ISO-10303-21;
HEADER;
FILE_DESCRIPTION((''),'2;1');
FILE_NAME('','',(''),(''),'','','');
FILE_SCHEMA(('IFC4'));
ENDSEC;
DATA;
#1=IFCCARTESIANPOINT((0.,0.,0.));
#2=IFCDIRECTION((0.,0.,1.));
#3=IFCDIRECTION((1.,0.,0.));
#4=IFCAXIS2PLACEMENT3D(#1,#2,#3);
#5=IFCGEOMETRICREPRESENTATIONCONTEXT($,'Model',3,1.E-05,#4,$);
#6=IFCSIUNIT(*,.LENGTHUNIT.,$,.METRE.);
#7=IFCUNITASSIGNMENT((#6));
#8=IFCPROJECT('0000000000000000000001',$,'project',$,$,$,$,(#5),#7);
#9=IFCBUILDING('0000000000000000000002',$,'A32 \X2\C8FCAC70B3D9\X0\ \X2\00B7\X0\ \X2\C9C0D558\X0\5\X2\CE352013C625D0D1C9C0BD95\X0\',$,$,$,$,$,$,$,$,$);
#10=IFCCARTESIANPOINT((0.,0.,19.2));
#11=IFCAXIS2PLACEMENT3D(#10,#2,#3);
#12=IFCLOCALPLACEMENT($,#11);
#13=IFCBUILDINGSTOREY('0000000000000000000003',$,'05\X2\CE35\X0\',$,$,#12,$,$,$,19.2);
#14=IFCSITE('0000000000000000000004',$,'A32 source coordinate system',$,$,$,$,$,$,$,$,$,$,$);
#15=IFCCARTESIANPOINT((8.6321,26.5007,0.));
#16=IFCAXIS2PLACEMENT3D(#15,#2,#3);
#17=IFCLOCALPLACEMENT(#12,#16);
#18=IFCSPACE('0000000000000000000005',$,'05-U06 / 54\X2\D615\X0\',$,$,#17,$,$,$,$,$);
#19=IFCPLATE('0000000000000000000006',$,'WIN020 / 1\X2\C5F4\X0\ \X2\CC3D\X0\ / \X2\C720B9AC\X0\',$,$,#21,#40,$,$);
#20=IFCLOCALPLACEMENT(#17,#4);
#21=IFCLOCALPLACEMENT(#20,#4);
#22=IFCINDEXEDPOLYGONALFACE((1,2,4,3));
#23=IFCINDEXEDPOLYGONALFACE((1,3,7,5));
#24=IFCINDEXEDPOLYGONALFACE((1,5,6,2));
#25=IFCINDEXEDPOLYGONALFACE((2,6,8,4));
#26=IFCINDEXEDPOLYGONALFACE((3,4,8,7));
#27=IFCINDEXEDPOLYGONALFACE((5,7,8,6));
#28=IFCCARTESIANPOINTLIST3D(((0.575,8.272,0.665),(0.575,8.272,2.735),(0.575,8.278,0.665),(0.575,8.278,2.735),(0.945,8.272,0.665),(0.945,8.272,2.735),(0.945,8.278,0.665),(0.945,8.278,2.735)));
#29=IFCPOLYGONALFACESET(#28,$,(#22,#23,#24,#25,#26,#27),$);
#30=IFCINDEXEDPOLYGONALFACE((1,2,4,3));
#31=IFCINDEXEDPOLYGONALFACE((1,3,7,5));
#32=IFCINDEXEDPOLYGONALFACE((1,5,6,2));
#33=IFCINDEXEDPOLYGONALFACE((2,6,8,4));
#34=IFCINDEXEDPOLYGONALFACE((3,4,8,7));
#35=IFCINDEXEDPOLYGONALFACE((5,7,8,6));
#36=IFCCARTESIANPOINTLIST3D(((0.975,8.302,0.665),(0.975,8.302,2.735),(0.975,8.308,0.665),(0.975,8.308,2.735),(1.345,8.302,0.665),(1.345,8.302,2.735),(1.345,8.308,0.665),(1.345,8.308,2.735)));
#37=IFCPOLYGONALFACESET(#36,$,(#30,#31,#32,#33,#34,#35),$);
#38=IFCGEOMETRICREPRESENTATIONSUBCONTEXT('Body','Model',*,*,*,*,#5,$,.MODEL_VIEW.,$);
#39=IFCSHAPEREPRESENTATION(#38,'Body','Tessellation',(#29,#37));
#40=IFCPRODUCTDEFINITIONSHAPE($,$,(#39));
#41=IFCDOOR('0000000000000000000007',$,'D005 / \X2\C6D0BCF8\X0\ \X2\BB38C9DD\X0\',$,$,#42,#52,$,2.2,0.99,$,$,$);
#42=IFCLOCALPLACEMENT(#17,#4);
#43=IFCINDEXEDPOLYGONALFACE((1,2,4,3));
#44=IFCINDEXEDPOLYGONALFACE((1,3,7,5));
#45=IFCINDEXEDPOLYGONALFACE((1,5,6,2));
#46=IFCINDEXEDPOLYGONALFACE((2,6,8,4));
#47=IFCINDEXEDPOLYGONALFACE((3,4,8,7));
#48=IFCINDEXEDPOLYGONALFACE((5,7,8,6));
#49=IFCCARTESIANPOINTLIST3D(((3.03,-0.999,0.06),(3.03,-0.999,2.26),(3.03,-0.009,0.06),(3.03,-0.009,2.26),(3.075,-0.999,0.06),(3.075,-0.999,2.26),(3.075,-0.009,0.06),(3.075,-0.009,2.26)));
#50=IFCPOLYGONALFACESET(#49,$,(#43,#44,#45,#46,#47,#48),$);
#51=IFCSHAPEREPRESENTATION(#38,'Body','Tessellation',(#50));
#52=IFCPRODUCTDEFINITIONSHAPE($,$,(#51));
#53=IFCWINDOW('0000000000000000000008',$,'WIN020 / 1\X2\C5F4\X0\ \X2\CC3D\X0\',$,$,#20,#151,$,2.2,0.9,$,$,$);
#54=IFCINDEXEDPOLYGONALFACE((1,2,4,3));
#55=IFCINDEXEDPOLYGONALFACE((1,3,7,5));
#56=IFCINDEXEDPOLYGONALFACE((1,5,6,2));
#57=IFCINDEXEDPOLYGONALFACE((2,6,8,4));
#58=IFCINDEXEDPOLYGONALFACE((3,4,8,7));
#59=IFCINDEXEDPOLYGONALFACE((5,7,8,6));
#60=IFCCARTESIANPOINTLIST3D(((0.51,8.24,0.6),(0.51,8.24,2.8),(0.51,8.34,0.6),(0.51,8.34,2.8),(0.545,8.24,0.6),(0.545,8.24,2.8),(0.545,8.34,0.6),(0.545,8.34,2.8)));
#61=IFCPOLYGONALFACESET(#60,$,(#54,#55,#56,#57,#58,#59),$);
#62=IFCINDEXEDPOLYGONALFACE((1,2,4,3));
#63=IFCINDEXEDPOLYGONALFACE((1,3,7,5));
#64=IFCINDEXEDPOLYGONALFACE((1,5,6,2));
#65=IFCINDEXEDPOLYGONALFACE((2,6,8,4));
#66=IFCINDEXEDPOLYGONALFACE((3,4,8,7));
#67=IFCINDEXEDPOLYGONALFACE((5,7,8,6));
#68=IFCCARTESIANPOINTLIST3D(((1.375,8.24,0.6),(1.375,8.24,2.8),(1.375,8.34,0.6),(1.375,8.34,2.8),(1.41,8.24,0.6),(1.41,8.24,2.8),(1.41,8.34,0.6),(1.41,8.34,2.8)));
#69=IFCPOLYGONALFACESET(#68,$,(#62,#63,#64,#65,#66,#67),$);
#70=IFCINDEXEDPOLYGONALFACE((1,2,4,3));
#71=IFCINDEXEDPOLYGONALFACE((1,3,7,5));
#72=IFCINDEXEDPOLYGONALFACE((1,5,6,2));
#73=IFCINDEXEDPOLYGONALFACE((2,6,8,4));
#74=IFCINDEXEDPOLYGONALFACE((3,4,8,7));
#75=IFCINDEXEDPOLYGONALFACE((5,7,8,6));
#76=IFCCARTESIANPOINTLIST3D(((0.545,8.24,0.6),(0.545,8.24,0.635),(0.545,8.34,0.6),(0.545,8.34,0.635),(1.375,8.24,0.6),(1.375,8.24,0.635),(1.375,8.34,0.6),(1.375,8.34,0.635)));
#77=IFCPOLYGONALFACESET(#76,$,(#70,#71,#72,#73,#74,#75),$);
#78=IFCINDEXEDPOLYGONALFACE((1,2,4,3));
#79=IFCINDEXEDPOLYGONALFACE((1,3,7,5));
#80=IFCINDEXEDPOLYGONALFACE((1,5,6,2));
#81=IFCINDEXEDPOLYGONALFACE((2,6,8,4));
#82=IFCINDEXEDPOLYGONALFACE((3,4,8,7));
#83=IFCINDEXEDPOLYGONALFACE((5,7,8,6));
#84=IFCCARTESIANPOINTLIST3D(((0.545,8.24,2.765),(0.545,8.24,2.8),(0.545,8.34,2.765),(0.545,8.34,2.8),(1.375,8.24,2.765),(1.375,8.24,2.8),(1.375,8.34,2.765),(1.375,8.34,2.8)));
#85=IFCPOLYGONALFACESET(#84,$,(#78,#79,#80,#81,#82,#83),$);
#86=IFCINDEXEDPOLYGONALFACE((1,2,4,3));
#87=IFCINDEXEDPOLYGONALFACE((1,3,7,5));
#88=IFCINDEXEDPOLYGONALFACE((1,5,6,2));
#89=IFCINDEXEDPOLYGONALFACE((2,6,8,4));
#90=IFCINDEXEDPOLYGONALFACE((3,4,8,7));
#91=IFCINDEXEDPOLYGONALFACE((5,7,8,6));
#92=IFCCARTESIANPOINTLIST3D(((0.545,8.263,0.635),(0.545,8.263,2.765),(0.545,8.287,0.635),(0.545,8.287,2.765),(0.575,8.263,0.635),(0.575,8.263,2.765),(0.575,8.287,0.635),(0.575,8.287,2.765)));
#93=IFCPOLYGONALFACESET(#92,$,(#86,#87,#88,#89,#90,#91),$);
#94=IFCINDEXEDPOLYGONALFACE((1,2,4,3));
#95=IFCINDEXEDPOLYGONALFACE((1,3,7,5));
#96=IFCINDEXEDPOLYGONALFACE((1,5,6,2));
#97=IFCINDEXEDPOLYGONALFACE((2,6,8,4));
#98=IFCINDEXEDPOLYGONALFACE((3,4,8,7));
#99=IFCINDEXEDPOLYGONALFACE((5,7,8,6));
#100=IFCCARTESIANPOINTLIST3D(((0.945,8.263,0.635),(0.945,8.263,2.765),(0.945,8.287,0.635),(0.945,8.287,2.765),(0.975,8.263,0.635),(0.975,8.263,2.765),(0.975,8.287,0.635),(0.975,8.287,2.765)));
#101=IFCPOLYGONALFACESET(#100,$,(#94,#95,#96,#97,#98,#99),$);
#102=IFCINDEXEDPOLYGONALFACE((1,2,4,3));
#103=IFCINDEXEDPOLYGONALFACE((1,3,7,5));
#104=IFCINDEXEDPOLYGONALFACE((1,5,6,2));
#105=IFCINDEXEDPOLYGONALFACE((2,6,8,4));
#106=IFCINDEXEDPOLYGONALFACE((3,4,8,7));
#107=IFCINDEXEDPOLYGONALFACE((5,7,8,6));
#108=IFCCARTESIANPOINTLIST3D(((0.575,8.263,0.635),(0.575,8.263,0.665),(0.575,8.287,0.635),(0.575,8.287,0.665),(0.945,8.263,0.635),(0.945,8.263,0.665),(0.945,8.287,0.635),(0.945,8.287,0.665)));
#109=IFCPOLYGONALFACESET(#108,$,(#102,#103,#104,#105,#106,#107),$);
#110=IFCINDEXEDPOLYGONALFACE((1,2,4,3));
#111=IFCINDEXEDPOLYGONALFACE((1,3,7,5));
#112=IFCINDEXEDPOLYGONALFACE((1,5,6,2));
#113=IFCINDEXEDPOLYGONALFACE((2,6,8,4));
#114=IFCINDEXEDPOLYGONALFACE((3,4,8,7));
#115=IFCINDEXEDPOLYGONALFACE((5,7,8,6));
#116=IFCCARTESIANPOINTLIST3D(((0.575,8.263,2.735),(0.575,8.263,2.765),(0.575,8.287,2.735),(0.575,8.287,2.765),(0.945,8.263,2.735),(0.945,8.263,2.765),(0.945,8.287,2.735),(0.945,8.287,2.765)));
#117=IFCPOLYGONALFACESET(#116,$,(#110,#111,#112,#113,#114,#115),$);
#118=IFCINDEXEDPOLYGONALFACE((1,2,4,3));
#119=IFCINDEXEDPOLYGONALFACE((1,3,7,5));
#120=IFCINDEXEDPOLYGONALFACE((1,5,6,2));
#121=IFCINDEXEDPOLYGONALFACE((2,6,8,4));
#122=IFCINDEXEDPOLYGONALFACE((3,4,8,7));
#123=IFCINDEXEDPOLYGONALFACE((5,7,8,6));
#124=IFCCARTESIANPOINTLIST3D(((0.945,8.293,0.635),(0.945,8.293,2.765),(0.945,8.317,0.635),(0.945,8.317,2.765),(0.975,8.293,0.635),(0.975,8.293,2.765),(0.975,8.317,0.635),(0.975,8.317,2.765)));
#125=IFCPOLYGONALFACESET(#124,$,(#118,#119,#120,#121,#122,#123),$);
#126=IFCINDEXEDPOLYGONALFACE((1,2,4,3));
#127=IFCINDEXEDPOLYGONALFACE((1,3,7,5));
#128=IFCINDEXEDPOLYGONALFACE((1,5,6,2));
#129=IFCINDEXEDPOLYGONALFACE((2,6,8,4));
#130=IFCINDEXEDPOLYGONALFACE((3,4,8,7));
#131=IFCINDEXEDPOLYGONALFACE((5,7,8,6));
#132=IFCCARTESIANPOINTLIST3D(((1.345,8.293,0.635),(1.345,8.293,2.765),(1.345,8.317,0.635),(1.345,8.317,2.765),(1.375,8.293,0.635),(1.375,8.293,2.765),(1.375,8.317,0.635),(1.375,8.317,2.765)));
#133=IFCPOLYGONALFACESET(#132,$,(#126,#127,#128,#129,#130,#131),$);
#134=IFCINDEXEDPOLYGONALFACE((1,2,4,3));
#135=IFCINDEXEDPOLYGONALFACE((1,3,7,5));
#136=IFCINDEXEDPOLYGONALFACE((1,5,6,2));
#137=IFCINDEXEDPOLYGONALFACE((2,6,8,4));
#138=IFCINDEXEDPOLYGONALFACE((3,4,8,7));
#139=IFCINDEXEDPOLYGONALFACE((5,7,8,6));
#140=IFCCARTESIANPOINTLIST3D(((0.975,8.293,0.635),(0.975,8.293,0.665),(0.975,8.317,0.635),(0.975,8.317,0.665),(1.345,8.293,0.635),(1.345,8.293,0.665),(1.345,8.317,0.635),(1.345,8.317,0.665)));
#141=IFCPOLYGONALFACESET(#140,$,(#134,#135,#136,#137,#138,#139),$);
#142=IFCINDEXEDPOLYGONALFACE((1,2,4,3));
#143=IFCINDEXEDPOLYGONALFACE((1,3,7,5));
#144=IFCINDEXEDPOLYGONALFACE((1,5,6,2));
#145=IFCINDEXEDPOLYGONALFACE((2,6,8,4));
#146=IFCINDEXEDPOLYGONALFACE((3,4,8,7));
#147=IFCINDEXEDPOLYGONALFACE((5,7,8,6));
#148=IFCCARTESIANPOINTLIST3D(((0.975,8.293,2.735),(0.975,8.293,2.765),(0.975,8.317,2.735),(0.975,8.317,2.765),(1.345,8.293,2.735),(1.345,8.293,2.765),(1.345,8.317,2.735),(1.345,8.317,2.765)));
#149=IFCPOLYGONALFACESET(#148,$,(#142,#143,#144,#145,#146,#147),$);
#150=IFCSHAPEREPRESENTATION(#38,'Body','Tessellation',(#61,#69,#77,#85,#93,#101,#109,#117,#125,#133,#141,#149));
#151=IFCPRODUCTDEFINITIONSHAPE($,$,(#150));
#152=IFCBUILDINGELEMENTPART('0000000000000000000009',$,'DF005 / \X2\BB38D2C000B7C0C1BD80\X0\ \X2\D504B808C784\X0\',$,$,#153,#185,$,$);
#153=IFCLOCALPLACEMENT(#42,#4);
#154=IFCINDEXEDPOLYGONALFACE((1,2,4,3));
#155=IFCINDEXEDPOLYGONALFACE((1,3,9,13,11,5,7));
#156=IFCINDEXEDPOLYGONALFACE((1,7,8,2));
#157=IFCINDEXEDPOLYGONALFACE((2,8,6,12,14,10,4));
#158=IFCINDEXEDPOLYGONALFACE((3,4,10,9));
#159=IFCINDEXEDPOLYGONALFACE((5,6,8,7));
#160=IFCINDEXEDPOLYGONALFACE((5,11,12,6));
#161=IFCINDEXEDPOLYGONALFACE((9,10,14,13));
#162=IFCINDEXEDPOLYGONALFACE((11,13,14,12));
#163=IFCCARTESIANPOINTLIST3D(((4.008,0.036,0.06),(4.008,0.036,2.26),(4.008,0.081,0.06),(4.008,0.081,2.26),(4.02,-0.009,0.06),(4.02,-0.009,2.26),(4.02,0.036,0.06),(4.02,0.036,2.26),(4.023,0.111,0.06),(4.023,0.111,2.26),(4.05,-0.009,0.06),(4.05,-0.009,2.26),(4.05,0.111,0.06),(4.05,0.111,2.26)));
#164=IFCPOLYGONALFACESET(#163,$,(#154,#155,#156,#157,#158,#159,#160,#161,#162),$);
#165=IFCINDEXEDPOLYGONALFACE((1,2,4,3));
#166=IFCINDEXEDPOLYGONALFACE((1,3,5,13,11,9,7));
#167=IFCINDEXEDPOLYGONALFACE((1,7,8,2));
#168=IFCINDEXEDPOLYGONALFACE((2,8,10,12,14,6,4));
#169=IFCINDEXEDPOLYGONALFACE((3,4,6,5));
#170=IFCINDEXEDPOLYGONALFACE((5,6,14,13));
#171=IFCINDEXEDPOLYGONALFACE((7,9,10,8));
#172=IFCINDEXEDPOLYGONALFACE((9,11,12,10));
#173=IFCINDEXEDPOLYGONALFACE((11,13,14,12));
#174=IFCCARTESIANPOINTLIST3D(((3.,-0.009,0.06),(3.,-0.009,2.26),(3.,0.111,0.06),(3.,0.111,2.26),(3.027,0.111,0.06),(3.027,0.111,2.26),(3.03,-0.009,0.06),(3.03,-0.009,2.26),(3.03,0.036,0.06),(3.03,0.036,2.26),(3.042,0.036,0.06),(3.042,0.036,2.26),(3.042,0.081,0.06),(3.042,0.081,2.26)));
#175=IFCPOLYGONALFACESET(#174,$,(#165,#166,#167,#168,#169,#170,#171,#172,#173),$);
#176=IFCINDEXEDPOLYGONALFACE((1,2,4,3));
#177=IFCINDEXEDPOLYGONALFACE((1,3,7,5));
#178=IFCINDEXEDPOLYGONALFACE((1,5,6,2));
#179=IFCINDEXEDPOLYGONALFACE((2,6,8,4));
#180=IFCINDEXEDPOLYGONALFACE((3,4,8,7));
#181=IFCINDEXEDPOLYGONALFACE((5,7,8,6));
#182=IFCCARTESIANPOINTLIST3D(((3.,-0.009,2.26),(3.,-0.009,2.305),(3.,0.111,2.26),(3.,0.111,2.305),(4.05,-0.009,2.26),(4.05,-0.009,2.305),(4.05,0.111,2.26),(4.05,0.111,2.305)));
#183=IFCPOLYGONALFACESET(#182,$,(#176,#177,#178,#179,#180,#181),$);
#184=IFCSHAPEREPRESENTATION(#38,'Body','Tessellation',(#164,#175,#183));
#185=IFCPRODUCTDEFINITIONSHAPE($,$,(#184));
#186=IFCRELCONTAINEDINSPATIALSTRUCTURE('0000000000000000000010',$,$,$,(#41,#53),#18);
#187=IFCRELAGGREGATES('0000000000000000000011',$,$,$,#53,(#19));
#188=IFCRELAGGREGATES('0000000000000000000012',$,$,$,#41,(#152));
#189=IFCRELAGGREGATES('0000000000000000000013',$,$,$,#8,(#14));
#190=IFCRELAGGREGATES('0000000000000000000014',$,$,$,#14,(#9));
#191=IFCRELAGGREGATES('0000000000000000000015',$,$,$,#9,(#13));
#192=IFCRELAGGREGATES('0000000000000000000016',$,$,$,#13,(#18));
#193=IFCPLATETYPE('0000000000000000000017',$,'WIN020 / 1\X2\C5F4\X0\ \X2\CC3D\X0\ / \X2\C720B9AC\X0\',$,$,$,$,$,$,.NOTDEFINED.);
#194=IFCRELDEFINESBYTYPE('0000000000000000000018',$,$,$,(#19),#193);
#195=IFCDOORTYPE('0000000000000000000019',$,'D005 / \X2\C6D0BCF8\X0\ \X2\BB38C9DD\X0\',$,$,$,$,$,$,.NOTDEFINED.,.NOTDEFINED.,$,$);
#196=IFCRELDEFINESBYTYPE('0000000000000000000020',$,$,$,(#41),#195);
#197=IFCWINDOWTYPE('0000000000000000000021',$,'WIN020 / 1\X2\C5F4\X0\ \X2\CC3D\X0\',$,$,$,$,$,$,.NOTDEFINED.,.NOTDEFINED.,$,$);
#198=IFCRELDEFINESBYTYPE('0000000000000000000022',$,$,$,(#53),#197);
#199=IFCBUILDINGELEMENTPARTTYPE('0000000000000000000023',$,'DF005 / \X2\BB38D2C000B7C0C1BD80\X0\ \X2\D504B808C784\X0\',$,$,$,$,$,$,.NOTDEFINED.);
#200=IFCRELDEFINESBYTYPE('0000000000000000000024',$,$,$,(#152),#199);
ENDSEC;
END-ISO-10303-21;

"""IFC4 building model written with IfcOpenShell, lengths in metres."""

from ifc_helpers import new_model, si_unit, frame, origin, origin_with_axes, place, context, subcontext, project, spatial, polyline, outline, extrude, source, transform, mapped, type_object, type_shapes, element, aggregate, save


model = new_model("IFC4")

# Units and contexts
model_context = context("Model", 3, precision=1e-05, world=origin_with_axes())
body_context = subcontext(model_context, "Body", "Model", "MODEL_VIEW")
ifc_project = project(units=[si_unit("LENGTHUNIT", "METRE")], contexts=[model_context])

# Plate
storey_placement = place(None, frame((0.0, 0.0, 19.2), z_axis=(0.0, 0.0, 1.0), x_axis=(1.0, 0.0, 0.0)))
space_1_placement = place(storey_placement, frame((8.6321, 26.5007, 0.0), z_axis=(0.0, 0.0, 1.0), x_axis=(1.0, 0.0, 0.0)))
plate_type_1 = type_object("IfcPlateType", Name="WIN020 / 1열 창 / 유리", PredefinedType="NOTDEFINED")
shared_shape_1 = source(origin(), body_context, "Body", "SweptSolid", [
    extrude(outline(polyline([(0.575, 8.272), (0.575, 8.278), (0.945, 8.278), (0.945, 8.272), (0.575, 8.272)])), frame((0.0, 0.0, 0.665)), (0.0, 0.0, 1.0), 2.07),
    extrude(outline(polyline([(0.975, 8.302), (0.975, 8.308), (1.345, 8.308), (1.345, 8.302), (0.975, 8.302)])), frame((0.0, 0.0, 0.665)), (0.0, 0.0, 1.0), 2.07),
])
type_shapes(plate_type_1, [shared_shape_1])
window_1_placement = place(space_1_placement, origin_with_axes())
plate_1_placement = place(window_1_placement, origin_with_axes())
plate_1 = element("IfcPlate", 1, at=plate_1_placement, type_object=plate_type_1, Name="WIN020 / 1열 창 / 유리", context=body_context, shape_type="MappedRepresentation", body=[
    mapped(shared_shape_1, transform((0.0, 0.0, 0.0), scale=1.0)),
])

# Site, building, storey, space
site = spatial("IfcSite", under=ifc_project, Name="A32 source coordinate system")
building = spatial("IfcBuilding", under=site, Name="A32 주거동 · 지하5층–옥탑지붕")
storey = spatial("IfcBuildingStorey", under=building, at=storey_placement, Name="05층", Elevation=19.2)
space_1 = spatial("IfcSpace", under=storey, at=space_1_placement, Name="05-U06 / 54형")

# Door
door_type_1 = type_object("IfcDoorType", Name="D005 / 원본 문짝", OperationType="NOTDEFINED", PredefinedType="NOTDEFINED")
shared_shape_2 = source(origin(), body_context, "Body", "SweptSolid", [
    extrude(outline(polyline([(3.075, -0.999), (3.03, -0.999), (3.03, -0.009), (3.075, -0.009), (3.075, -0.999)])), frame((0.0, 0.0, 0.06)), (0.0, 0.0, 1.0), 2.2),
])
type_shapes(door_type_1, [shared_shape_2])
door_1_placement = place(space_1_placement, origin_with_axes())
door_1 = element("IfcDoor", 2, at=door_1_placement, inside=space_1, type_object=door_type_1, Name="D005 / 원본 문짝", OverallHeight=2.2, OverallWidth=0.99, context=body_context, shape_type="MappedRepresentation", body=[
    mapped(shared_shape_2, transform((0.0, 0.0, 0.0), scale=1.0)),
])

# Window
window_type_1 = type_object("IfcWindowType", Name="WIN020 / 1열 창", PartitioningType="NOTDEFINED", PredefinedType="NOTDEFINED")
shared_shape_3 = source(origin(), body_context, "Body", "SweptSolid", [
    extrude(outline(polyline([(0.51, 8.24), (0.51, 8.34), (0.545, 8.34), (0.545, 8.24), (0.51, 8.24)])), frame((0.0, 0.0, 0.6)), (0.0, 0.0, 1.0), 2.2),
    extrude(outline(polyline([(1.375, 8.24), (1.375, 8.34), (1.41, 8.34), (1.41, 8.24), (1.375, 8.24)])), frame((0.0, 0.0, 0.6)), (0.0, 0.0, 1.0), 2.2),
    extrude(outline(polyline([(0.545, 8.24), (0.545, 8.34), (1.375, 8.34), (1.375, 8.24), (0.545, 8.24)])), frame((0.0, 0.0, 0.6)), (0.0, 0.0, 1.0), 0.035),
    extrude(outline(polyline([(0.545, 8.24), (0.545, 8.34), (1.375, 8.34), (1.375, 8.24), (0.545, 8.24)])), frame((0.0, 0.0, 2.765)), (0.0, 0.0, 1.0), 0.035),
    extrude(outline(polyline([(0.545, 8.263), (0.545, 8.287), (0.575, 8.287), (0.575, 8.263), (0.545, 8.263)])), frame((0.0, 0.0, 0.635)), (0.0, 0.0, 1.0), 2.13),
    extrude(outline(polyline([(0.945, 8.263), (0.945, 8.287), (0.975, 8.287), (0.975, 8.263), (0.945, 8.263)])), frame((0.0, 0.0, 0.635)), (0.0, 0.0, 1.0), 2.13),
    extrude(outline(polyline([(0.575, 8.263), (0.575, 8.287), (0.945, 8.287), (0.945, 8.263), (0.575, 8.263)])), frame((0.0, 0.0, 0.635)), (0.0, 0.0, 1.0), 0.03),
    extrude(outline(polyline([(0.575, 8.263), (0.575, 8.287), (0.945, 8.287), (0.945, 8.263), (0.575, 8.263)])), frame((0.0, 0.0, 2.735)), (0.0, 0.0, 1.0), 0.03),
    extrude(outline(polyline([(0.945, 8.293), (0.945, 8.317), (0.975, 8.317), (0.975, 8.293), (0.945, 8.293)])), frame((0.0, 0.0, 0.635)), (0.0, 0.0, 1.0), 2.13),
    extrude(outline(polyline([(1.345, 8.293), (1.345, 8.317), (1.375, 8.317), (1.375, 8.293), (1.345, 8.293)])), frame((0.0, 0.0, 0.635)), (0.0, 0.0, 1.0), 2.13),
    extrude(outline(polyline([(0.975, 8.293), (0.975, 8.317), (1.345, 8.317), (1.345, 8.293), (0.975, 8.293)])), frame((0.0, 0.0, 0.635)), (0.0, 0.0, 1.0), 0.03),
    extrude(outline(polyline([(0.975, 8.293), (0.975, 8.317), (1.345, 8.317), (1.345, 8.293), (0.975, 8.293)])), frame((0.0, 0.0, 2.735)), (0.0, 0.0, 1.0), 0.03),
])
type_shapes(window_type_1, [shared_shape_3])
window_1 = element("IfcWindow", 3, at=window_1_placement, inside=space_1, type_object=window_type_1, Name="WIN020 / 1열 창", OverallHeight=2.2, OverallWidth=0.9, context=body_context, shape_type="MappedRepresentation", body=[
    mapped(shared_shape_3, transform((0.0, 0.0, 0.0), scale=1.0)),
])
aggregate(window_1, [plate_1])

# Building element part
building_element_part_type_1 = type_object("IfcBuildingElementPartType", Name="DF005 / 문틀·상부 프레임", PredefinedType="NOTDEFINED")
shared_shape_4 = source(origin(), body_context, "Body", "SweptSolid", [
    extrude(outline(polyline([(4.02, -0.009), (4.02, 0.036), (4.008, 0.036), (4.008, 0.081), (4.023, 0.111), (4.05, 0.111), (4.05, -0.009), (4.02, -0.009)])), frame((0.0, 0.0, 0.06)), (0.0, 0.0, 1.0), 2.2),
    extrude(outline(polyline([(3.0, 0.111), (3.027, 0.111), (3.042, 0.081), (3.042, 0.036), (3.03, 0.036), (3.03, -0.009), (3.0, -0.009), (3.0, 0.111)])), frame((0.0, 0.0, 0.06)), (0.0, 0.0, 1.0), 2.2),
    extrude(outline(polyline([(3.0, -0.009), (3.0, 0.111), (4.05, 0.111), (4.05, -0.009), (3.0, -0.009)])), frame((0.0, 0.0, 2.26)), (0.0, 0.0, 1.0), 0.045),
])
type_shapes(building_element_part_type_1, [shared_shape_4])
building_element_part_1_placement = place(door_1_placement, origin_with_axes())
building_element_part_1 = element("IfcBuildingElementPart", 4, at=building_element_part_1_placement, type_object=building_element_part_type_1, Name="DF005 / 문틀·상부 프레임", context=body_context, shape_type="MappedRepresentation", body=[
    mapped(shared_shape_4, transform((0.0, 0.0, 0.0), scale=1.0)),
])
aggregate(door_1, [building_element_part_1])

save(model, "model.ifc")
